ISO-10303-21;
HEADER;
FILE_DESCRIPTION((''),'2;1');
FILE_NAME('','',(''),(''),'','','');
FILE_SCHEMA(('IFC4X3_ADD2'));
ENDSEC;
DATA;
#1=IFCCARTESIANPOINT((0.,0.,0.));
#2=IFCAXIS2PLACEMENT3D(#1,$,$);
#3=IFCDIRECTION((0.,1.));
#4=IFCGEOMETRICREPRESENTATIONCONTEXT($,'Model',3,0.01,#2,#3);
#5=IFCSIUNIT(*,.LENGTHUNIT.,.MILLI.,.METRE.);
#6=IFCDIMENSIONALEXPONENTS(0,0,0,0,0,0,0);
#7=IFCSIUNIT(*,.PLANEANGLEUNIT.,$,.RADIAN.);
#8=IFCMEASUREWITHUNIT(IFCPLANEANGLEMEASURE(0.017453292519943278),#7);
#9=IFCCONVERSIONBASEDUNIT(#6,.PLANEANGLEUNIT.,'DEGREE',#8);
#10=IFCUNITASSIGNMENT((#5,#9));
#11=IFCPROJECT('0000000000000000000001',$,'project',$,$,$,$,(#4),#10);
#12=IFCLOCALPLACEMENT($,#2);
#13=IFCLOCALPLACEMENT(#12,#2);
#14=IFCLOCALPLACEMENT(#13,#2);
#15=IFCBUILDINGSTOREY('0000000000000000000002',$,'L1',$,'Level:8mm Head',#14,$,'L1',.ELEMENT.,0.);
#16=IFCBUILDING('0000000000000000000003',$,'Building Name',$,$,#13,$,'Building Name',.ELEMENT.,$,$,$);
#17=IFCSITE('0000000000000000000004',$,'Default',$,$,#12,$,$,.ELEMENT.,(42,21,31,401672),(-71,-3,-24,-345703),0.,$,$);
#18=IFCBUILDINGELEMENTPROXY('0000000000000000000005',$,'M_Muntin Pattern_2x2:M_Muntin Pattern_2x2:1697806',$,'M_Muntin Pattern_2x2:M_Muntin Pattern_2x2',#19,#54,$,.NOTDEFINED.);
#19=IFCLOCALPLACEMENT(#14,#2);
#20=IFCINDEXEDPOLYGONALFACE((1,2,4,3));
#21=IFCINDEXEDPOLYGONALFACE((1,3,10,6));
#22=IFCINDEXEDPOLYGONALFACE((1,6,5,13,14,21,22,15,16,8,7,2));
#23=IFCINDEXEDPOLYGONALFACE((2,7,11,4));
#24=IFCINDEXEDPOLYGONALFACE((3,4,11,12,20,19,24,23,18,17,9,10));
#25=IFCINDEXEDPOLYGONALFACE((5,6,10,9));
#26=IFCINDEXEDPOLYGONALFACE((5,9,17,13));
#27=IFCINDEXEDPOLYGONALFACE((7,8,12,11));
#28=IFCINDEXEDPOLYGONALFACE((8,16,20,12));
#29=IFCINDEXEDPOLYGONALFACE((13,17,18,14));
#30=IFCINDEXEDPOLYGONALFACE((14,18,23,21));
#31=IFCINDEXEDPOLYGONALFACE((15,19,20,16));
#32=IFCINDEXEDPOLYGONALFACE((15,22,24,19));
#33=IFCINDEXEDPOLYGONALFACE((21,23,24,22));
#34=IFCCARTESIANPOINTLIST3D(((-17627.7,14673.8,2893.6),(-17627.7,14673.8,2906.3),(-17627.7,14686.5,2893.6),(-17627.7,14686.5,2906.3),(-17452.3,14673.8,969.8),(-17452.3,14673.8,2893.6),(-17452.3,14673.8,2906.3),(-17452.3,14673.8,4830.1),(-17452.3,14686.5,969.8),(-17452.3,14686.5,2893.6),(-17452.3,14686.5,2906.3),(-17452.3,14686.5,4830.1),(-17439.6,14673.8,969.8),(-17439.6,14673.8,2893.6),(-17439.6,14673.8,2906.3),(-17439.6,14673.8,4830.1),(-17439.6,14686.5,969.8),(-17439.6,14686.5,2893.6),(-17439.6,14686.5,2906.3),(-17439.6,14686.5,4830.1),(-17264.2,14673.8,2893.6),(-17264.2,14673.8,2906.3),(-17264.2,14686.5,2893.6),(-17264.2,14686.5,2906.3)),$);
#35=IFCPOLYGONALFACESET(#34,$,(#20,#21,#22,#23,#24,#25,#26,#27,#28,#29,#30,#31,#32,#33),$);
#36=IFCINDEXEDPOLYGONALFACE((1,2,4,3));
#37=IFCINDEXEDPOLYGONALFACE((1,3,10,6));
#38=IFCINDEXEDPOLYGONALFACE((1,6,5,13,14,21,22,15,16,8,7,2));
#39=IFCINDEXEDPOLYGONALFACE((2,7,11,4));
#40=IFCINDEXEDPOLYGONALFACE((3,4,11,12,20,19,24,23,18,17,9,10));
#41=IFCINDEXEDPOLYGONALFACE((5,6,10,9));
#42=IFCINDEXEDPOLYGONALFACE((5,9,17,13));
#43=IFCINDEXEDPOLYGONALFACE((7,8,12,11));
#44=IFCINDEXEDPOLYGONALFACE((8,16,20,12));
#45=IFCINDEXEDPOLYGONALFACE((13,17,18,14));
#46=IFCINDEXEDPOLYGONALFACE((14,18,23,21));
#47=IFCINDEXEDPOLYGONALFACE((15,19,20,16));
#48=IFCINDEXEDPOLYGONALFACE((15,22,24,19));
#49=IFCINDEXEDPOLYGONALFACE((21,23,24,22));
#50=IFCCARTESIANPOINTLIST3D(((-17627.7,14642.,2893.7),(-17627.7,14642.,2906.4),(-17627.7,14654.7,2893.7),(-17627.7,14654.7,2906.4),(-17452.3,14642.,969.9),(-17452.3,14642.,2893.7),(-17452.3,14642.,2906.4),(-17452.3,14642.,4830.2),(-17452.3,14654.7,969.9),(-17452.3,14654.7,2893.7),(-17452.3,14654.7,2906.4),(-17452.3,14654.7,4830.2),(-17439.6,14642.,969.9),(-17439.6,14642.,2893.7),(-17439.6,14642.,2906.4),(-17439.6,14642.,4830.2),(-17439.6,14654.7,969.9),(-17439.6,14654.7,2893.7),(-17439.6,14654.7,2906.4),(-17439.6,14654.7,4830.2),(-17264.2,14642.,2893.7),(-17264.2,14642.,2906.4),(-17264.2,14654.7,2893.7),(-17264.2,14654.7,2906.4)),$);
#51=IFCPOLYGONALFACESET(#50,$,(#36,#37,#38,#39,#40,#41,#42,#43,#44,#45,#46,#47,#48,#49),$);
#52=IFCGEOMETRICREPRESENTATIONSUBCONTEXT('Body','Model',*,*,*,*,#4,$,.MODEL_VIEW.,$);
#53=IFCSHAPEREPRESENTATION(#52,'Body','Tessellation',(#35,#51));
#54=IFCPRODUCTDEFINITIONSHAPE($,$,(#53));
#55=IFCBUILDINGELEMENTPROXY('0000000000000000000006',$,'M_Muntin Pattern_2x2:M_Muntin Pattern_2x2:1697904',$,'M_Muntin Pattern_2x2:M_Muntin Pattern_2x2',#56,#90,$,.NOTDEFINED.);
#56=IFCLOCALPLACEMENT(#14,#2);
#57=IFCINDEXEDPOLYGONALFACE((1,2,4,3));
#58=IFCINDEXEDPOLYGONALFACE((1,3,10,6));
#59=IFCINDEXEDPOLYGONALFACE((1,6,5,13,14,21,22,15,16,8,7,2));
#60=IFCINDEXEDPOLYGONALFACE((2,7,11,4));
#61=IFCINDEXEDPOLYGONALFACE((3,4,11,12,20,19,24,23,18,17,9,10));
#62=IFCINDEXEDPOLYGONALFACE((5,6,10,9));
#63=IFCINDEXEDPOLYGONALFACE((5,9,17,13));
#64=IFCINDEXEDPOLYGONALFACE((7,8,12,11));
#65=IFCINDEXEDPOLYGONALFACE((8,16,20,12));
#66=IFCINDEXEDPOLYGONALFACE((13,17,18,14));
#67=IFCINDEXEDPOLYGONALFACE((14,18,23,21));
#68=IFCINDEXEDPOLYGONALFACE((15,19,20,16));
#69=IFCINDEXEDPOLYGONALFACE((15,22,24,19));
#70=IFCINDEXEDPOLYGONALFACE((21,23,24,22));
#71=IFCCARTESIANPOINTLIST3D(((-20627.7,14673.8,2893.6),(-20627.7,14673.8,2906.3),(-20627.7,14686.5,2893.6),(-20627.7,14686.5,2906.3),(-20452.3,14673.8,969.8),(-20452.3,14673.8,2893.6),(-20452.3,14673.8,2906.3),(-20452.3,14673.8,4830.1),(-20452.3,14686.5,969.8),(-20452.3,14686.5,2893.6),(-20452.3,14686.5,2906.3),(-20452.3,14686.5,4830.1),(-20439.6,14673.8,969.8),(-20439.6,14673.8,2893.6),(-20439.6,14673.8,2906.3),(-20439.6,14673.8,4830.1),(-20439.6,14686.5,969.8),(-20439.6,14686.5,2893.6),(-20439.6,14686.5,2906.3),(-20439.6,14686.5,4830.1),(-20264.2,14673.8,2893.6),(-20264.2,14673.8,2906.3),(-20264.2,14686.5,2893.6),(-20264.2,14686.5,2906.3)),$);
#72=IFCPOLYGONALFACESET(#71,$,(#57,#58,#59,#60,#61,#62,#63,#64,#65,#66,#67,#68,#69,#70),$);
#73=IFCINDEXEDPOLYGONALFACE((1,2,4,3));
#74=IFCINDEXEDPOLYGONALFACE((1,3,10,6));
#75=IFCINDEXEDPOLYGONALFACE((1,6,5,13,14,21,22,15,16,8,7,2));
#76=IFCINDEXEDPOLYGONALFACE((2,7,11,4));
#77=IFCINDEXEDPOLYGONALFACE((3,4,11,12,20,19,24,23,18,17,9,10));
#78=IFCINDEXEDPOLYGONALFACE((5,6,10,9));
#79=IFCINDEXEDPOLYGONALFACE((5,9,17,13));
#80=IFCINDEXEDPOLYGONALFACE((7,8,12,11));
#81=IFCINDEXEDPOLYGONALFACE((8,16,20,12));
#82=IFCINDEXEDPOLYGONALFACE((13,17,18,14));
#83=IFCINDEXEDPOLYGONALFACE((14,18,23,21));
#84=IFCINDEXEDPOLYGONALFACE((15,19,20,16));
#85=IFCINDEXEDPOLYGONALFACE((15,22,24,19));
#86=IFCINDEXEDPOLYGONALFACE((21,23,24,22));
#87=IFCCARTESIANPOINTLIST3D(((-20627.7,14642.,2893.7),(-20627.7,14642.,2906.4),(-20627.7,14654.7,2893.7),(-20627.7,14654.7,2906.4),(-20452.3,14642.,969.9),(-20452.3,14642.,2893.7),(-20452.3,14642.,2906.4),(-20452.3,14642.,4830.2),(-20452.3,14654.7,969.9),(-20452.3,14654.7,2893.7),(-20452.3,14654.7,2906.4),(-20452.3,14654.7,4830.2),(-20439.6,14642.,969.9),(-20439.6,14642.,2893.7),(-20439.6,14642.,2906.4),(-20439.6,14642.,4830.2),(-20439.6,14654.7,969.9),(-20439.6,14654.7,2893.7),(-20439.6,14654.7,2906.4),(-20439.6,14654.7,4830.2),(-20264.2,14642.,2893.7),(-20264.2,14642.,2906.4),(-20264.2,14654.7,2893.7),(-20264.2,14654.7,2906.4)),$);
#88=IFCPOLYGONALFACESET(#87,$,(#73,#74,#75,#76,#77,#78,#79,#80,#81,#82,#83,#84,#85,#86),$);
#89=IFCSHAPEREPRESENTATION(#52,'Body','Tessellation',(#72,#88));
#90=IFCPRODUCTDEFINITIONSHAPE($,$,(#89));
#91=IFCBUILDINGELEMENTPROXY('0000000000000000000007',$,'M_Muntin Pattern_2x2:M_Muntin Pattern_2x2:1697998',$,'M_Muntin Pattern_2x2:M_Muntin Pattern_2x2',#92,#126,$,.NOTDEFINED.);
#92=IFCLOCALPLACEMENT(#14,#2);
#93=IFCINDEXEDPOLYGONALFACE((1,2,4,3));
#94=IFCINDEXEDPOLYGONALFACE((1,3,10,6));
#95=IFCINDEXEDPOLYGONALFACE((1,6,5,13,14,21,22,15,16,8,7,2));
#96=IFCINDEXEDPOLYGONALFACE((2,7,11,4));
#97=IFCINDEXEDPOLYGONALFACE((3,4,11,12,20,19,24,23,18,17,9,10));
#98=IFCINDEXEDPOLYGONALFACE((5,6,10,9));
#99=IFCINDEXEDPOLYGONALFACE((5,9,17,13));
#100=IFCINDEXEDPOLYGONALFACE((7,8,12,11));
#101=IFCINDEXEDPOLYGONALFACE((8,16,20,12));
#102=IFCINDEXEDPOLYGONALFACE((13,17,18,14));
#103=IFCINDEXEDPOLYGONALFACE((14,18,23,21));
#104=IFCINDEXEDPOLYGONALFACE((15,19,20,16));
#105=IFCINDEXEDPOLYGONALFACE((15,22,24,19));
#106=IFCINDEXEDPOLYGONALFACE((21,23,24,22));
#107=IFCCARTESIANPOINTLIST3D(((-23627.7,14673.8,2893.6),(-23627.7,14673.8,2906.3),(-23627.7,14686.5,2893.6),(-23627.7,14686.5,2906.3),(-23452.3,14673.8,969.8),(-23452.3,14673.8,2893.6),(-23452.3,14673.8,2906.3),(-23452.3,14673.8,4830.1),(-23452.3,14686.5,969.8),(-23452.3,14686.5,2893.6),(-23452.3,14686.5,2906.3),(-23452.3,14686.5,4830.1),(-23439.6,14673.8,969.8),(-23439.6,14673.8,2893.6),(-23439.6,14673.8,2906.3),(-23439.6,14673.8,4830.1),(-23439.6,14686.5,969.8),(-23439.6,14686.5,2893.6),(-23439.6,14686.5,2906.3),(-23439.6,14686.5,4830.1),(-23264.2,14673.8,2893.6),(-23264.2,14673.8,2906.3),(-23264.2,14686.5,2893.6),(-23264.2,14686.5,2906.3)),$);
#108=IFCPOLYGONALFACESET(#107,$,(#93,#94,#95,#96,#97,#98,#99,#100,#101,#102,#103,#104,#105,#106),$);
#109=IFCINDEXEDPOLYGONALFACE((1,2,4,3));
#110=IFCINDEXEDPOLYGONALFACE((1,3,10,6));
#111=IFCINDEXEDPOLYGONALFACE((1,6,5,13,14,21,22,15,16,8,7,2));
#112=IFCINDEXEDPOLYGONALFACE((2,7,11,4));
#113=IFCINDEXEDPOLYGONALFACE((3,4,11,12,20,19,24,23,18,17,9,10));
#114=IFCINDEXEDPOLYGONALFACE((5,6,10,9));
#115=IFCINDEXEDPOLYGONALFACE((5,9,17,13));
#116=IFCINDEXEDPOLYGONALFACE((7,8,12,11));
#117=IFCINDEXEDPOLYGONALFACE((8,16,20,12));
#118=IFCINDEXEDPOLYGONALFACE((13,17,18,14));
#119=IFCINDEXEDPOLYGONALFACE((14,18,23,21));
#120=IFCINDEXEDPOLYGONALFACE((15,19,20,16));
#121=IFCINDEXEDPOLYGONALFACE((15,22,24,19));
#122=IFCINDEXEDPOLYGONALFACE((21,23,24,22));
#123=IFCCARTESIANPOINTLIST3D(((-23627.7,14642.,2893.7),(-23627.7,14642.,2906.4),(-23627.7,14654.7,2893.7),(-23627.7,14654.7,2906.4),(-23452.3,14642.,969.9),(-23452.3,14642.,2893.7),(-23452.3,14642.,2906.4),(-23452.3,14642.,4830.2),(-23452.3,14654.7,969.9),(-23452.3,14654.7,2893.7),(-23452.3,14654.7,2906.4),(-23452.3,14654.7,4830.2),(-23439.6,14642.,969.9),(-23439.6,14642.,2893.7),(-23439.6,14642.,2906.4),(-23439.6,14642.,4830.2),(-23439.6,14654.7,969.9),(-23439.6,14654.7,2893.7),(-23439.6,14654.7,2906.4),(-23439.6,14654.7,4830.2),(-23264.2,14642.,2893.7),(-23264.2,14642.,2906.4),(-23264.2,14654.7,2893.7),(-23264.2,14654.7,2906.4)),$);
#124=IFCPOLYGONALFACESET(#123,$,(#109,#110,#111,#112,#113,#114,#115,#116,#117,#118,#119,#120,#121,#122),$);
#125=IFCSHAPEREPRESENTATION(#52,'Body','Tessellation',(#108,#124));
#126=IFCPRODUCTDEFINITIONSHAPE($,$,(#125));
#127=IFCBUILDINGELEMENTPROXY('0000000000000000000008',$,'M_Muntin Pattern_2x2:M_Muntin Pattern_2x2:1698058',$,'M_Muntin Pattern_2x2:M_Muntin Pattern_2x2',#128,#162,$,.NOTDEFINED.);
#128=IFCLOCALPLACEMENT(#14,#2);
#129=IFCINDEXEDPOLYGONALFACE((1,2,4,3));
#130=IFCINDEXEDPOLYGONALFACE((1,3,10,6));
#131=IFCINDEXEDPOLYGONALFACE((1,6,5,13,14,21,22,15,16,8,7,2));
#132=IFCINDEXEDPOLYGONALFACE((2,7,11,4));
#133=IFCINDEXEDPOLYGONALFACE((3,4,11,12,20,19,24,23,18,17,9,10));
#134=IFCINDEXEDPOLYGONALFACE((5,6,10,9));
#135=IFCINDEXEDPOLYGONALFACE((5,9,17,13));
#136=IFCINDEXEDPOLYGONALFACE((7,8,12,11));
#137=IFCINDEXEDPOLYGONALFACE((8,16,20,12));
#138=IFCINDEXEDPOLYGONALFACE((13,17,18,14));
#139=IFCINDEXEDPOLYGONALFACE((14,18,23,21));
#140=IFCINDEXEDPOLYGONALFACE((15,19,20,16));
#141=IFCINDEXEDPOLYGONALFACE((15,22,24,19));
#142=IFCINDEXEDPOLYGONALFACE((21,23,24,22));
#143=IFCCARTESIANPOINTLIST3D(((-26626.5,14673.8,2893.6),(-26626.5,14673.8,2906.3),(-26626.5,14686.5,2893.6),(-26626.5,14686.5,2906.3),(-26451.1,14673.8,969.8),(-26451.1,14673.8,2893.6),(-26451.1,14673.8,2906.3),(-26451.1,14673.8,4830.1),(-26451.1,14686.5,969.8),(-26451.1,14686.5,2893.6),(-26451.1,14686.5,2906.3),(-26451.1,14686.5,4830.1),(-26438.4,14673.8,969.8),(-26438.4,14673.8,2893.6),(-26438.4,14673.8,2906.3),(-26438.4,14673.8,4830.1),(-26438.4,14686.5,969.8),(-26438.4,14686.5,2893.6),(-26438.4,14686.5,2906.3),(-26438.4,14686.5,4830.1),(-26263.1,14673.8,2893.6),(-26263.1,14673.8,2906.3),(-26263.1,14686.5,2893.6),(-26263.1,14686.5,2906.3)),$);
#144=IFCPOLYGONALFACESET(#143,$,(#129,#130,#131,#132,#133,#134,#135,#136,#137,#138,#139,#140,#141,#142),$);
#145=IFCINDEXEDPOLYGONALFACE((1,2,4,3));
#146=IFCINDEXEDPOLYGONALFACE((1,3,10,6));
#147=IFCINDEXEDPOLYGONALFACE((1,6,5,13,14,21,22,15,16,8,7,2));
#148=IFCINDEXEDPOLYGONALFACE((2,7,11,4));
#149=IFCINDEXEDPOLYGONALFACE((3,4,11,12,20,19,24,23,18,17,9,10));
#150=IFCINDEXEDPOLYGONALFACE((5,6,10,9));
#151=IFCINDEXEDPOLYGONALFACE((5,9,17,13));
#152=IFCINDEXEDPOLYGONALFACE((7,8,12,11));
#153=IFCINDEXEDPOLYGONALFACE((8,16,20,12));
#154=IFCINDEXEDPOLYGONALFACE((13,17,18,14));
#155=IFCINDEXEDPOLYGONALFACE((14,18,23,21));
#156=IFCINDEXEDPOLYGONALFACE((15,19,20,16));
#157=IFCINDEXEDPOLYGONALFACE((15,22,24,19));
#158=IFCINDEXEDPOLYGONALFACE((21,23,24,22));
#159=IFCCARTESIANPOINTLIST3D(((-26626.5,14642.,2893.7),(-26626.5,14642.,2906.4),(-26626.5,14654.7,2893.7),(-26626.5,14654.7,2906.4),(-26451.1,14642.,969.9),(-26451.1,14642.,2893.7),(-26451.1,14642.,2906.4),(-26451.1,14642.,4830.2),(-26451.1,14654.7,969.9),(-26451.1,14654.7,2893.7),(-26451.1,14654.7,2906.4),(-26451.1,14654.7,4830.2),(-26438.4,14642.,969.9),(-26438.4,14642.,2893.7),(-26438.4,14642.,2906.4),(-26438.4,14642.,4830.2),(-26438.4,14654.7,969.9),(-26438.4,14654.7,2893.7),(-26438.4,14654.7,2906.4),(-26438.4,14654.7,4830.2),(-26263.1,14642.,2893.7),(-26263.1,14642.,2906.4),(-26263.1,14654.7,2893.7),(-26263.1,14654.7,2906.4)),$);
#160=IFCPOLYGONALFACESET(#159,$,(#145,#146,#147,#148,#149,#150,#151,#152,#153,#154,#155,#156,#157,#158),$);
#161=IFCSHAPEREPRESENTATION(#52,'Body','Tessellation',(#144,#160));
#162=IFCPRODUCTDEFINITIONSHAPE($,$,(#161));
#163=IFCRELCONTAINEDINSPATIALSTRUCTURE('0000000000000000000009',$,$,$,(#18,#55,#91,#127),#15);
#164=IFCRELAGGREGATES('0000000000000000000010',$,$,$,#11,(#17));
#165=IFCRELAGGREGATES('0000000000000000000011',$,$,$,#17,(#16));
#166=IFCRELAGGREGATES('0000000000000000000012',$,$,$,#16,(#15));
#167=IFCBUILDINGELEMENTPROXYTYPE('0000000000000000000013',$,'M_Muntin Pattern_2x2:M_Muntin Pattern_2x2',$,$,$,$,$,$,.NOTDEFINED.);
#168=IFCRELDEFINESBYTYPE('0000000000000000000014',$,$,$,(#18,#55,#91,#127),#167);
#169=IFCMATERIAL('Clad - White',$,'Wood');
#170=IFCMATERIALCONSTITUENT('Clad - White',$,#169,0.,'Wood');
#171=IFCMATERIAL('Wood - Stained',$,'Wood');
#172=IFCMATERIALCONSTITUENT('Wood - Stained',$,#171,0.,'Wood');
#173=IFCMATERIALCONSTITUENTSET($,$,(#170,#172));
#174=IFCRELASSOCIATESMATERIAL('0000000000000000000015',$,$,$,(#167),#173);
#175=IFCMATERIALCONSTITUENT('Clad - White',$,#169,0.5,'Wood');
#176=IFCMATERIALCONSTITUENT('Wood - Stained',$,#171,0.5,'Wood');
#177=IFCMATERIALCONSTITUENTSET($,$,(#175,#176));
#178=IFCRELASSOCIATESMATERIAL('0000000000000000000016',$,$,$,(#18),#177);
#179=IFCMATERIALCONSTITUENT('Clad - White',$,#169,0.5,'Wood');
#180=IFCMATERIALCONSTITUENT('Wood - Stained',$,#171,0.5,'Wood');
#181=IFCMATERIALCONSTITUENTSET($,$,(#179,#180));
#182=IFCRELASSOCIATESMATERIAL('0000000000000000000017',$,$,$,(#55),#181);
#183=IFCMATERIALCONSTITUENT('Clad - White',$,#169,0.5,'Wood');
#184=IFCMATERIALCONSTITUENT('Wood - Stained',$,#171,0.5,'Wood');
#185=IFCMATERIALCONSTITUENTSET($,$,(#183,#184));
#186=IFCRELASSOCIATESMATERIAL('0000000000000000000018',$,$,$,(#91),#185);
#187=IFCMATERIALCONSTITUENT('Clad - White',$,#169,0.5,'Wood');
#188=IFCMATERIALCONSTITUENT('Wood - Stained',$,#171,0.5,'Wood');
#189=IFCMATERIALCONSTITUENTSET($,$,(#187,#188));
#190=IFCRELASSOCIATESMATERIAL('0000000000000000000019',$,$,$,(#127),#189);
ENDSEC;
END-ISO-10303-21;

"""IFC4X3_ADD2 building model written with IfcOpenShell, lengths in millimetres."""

from ifc_helpers import new_model, entity, si_unit, converted_unit, direction, frame, origin, place, context, subcontext, project, spatial, polyline, outline, extrude, source, transform, mapped, material, constituent, constituent_set, type_object, type_shapes, element, save


model = new_model("IFC4X3_ADD2")

# Units and contexts
model_context = context("Model", 3, precision=0.01, world=origin(), true_north=direction((0.0, 1.0)))
body_context = subcontext(model_context, "Body", "Model", "MODEL_VIEW")
ifc_project = project(units=[si_unit("LENGTHUNIT", "METRE", prefix="MILLI"), converted_unit("PLANEANGLEUNIT", "DEGREE", entity("IfcPlaneAngleMeasure", 0.017453292519943278), si_unit("PLANEANGLEUNIT", "RADIAN"), dimensions=[0, 0, 0, 0, 0, 0, 0])], contexts=[model_context])

# Site, building, storey
site_placement = place(None, origin())
site = spatial("IfcSite", under=ifc_project, at=site_placement, Name="Default", CompositionType="ELEMENT", RefLatitude=(42, 21, 31, 401672), RefLongitude=(-71, -3, -24, -345703), RefElevation=0.0)
building_placement = place(site_placement, origin())
building = spatial("IfcBuilding", under=site, at=building_placement, Name="Building Name", LongName="Building Name", CompositionType="ELEMENT")
storey_placement = place(building_placement, origin())
storey = spatial("IfcBuildingStorey", under=building, at=storey_placement, Name="L1", ObjectType="Level:8mm Head", LongName="L1", CompositionType="ELEMENT", Elevation=0.0)

# Building element proxies
ifc_material_1 = material(Name="Clad - White", Category="Wood")
ifc_material_2 = material(Name="Wood - Stained", Category="Wood")
ifc_constituent_1 = constituent(ifc_material_1, Name="Clad - White", Category="Wood", fraction=0.0)
ifc_constituent_2 = constituent(ifc_material_2, Name="Wood - Stained", Category="Wood", fraction=0.0)
ifc_constituent_set_1 = constituent_set(constituents=[ifc_constituent_1, ifc_constituent_2])
building_element_proxy_type_1 = type_object("IfcBuildingElementProxyType", Name="M_Muntin Pattern_2x2:M_Muntin Pattern_2x2", PredefinedType="NOTDEFINED", material=ifc_constituent_set_1)
shared_shape_1 = source(origin(), body_context, "Body", "SweptSolid", [
    extrude(outline(polyline([(6.4, -6.4), (1930.1, -6.4), (1930.1, 6.3), (6.4, 6.3), (6.4, 181.7), (-6.3, 181.7), (-6.3, 6.3), (-1930.2, 6.3), (-1930.2, -6.4), (-6.3, -6.4), (-6.3, -181.7), (6.4, -181.7), (6.4, -6.4)])), frame((0.0, -22.2, 1930.1), z_axis=(0.0, 1.0, 0.0), x_axis=(0.0, 0.0, 1.0)), (0.0, 0.0, 1.0), 12.7),
    extrude(outline(polyline([(6.4, -6.4), (1930.2, -6.4), (1930.2, 6.3), (6.4, 6.3), (6.4, 181.7), (-6.3, 181.7), (-6.3, 6.3), (-1930.2, 6.3), (-1930.2, -6.4), (-6.3, -6.4), (-6.3, -181.7), (6.4, -181.7), (6.4, -6.4)])), frame((0.0, 9.5, 1930.2), z_axis=(0.0, 1.0, 0.0), x_axis=(0.0, 0.0, 1.0)), (0.0, 0.0, 1.0), 12.7),
])
type_shapes(building_element_proxy_type_1, [shared_shape_1])
ifc_constituent_3 = constituent(ifc_material_1, Name="Clad - White", Category="Wood", fraction=0.5)
ifc_constituent_4 = constituent(ifc_material_2, Name="Wood - Stained", Category="Wood", fraction=0.5)
ifc_constituent_set_2 = constituent_set(constituents=[ifc_constituent_3, ifc_constituent_4])
proxy_1_placement = place(storey_placement, frame((-17445.9, 14664.3, 969.9), z_axis=(0.0, 0.0, 1.0), x_axis=(-1.0, 0.0, 0.0)))
element("IfcBuildingElementProxy", 1, at=proxy_1_placement, inside=storey, type_object=building_element_proxy_type_1, material=ifc_constituent_set_2, Name="M_Muntin Pattern_2x2:M_Muntin Pattern_2x2:1697806", ObjectType="M_Muntin Pattern_2x2:M_Muntin Pattern_2x2", PredefinedType="NOTDEFINED", context=body_context, shape_type="MappedRepresentation", body=[
    mapped(shared_shape_1, transform((0.0, 0.0, 0.0), scale=1.0)),
])
ifc_constituent_5 = constituent(ifc_material_1, Name="Clad - White", Category="Wood", fraction=0.5)
ifc_constituent_6 = constituent(ifc_material_2, Name="Wood - Stained", Category="Wood", fraction=0.5)
ifc_constituent_set_3 = constituent_set(constituents=[ifc_constituent_5, ifc_constituent_6])
proxy_2_placement = place(storey_placement, frame((-20445.9, 14664.3, 969.9), z_axis=(0.0, 0.0, 1.0), x_axis=(-1.0, 0.0, 0.0)))
element("IfcBuildingElementProxy", 2, at=proxy_2_placement, inside=storey, type_object=building_element_proxy_type_1, material=ifc_constituent_set_3, Name="M_Muntin Pattern_2x2:M_Muntin Pattern_2x2:1697904", ObjectType="M_Muntin Pattern_2x2:M_Muntin Pattern_2x2", PredefinedType="NOTDEFINED", context=body_context, shape_type="MappedRepresentation", body=[
    mapped(shared_shape_1, transform((0.0, 0.0, 0.0), scale=1.0)),
])
ifc_constituent_7 = constituent(ifc_material_1, Name="Clad - White", Category="Wood", fraction=0.5)
ifc_constituent_8 = constituent(ifc_material_2, Name="Wood - Stained", Category="Wood", fraction=0.5)
ifc_constituent_set_4 = constituent_set(constituents=[ifc_constituent_7, ifc_constituent_8])
proxy_3_placement = place(storey_placement, frame((-23445.9, 14664.3, 969.9), z_axis=(0.0, 0.0, 1.0), x_axis=(-1.0, 0.0, 0.0)))
element("IfcBuildingElementProxy", 3, at=proxy_3_placement, inside=storey, type_object=building_element_proxy_type_1, material=ifc_constituent_set_4, Name="M_Muntin Pattern_2x2:M_Muntin Pattern_2x2:1697998", ObjectType="M_Muntin Pattern_2x2:M_Muntin Pattern_2x2", PredefinedType="NOTDEFINED", context=body_context, shape_type="MappedRepresentation", body=[
    mapped(shared_shape_1, transform((0.0, 0.0, 0.0), scale=1.0)),
])
ifc_constituent_9 = constituent(ifc_material_1, Name="Clad - White", Category="Wood", fraction=0.5)
ifc_constituent_10 = constituent(ifc_material_2, Name="Wood - Stained", Category="Wood", fraction=0.5)
ifc_constituent_set_5 = constituent_set(constituents=[ifc_constituent_9, ifc_constituent_10])
proxy_4_placement = place(storey_placement, frame((-26444.8, 14664.3, 969.9), z_axis=(0.0, 0.0, 1.0), x_axis=(-1.0, 0.0, 0.0)))
element("IfcBuildingElementProxy", 4, at=proxy_4_placement, inside=storey, type_object=building_element_proxy_type_1, material=ifc_constituent_set_5, Name="M_Muntin Pattern_2x2:M_Muntin Pattern_2x2:1698058", ObjectType="M_Muntin Pattern_2x2:M_Muntin Pattern_2x2", PredefinedType="NOTDEFINED", context=body_context, shape_type="MappedRepresentation", body=[
    mapped(shared_shape_1, transform((0.0, 0.0, 0.0), scale=1.0)),
])

save(model, "model.ifc")
